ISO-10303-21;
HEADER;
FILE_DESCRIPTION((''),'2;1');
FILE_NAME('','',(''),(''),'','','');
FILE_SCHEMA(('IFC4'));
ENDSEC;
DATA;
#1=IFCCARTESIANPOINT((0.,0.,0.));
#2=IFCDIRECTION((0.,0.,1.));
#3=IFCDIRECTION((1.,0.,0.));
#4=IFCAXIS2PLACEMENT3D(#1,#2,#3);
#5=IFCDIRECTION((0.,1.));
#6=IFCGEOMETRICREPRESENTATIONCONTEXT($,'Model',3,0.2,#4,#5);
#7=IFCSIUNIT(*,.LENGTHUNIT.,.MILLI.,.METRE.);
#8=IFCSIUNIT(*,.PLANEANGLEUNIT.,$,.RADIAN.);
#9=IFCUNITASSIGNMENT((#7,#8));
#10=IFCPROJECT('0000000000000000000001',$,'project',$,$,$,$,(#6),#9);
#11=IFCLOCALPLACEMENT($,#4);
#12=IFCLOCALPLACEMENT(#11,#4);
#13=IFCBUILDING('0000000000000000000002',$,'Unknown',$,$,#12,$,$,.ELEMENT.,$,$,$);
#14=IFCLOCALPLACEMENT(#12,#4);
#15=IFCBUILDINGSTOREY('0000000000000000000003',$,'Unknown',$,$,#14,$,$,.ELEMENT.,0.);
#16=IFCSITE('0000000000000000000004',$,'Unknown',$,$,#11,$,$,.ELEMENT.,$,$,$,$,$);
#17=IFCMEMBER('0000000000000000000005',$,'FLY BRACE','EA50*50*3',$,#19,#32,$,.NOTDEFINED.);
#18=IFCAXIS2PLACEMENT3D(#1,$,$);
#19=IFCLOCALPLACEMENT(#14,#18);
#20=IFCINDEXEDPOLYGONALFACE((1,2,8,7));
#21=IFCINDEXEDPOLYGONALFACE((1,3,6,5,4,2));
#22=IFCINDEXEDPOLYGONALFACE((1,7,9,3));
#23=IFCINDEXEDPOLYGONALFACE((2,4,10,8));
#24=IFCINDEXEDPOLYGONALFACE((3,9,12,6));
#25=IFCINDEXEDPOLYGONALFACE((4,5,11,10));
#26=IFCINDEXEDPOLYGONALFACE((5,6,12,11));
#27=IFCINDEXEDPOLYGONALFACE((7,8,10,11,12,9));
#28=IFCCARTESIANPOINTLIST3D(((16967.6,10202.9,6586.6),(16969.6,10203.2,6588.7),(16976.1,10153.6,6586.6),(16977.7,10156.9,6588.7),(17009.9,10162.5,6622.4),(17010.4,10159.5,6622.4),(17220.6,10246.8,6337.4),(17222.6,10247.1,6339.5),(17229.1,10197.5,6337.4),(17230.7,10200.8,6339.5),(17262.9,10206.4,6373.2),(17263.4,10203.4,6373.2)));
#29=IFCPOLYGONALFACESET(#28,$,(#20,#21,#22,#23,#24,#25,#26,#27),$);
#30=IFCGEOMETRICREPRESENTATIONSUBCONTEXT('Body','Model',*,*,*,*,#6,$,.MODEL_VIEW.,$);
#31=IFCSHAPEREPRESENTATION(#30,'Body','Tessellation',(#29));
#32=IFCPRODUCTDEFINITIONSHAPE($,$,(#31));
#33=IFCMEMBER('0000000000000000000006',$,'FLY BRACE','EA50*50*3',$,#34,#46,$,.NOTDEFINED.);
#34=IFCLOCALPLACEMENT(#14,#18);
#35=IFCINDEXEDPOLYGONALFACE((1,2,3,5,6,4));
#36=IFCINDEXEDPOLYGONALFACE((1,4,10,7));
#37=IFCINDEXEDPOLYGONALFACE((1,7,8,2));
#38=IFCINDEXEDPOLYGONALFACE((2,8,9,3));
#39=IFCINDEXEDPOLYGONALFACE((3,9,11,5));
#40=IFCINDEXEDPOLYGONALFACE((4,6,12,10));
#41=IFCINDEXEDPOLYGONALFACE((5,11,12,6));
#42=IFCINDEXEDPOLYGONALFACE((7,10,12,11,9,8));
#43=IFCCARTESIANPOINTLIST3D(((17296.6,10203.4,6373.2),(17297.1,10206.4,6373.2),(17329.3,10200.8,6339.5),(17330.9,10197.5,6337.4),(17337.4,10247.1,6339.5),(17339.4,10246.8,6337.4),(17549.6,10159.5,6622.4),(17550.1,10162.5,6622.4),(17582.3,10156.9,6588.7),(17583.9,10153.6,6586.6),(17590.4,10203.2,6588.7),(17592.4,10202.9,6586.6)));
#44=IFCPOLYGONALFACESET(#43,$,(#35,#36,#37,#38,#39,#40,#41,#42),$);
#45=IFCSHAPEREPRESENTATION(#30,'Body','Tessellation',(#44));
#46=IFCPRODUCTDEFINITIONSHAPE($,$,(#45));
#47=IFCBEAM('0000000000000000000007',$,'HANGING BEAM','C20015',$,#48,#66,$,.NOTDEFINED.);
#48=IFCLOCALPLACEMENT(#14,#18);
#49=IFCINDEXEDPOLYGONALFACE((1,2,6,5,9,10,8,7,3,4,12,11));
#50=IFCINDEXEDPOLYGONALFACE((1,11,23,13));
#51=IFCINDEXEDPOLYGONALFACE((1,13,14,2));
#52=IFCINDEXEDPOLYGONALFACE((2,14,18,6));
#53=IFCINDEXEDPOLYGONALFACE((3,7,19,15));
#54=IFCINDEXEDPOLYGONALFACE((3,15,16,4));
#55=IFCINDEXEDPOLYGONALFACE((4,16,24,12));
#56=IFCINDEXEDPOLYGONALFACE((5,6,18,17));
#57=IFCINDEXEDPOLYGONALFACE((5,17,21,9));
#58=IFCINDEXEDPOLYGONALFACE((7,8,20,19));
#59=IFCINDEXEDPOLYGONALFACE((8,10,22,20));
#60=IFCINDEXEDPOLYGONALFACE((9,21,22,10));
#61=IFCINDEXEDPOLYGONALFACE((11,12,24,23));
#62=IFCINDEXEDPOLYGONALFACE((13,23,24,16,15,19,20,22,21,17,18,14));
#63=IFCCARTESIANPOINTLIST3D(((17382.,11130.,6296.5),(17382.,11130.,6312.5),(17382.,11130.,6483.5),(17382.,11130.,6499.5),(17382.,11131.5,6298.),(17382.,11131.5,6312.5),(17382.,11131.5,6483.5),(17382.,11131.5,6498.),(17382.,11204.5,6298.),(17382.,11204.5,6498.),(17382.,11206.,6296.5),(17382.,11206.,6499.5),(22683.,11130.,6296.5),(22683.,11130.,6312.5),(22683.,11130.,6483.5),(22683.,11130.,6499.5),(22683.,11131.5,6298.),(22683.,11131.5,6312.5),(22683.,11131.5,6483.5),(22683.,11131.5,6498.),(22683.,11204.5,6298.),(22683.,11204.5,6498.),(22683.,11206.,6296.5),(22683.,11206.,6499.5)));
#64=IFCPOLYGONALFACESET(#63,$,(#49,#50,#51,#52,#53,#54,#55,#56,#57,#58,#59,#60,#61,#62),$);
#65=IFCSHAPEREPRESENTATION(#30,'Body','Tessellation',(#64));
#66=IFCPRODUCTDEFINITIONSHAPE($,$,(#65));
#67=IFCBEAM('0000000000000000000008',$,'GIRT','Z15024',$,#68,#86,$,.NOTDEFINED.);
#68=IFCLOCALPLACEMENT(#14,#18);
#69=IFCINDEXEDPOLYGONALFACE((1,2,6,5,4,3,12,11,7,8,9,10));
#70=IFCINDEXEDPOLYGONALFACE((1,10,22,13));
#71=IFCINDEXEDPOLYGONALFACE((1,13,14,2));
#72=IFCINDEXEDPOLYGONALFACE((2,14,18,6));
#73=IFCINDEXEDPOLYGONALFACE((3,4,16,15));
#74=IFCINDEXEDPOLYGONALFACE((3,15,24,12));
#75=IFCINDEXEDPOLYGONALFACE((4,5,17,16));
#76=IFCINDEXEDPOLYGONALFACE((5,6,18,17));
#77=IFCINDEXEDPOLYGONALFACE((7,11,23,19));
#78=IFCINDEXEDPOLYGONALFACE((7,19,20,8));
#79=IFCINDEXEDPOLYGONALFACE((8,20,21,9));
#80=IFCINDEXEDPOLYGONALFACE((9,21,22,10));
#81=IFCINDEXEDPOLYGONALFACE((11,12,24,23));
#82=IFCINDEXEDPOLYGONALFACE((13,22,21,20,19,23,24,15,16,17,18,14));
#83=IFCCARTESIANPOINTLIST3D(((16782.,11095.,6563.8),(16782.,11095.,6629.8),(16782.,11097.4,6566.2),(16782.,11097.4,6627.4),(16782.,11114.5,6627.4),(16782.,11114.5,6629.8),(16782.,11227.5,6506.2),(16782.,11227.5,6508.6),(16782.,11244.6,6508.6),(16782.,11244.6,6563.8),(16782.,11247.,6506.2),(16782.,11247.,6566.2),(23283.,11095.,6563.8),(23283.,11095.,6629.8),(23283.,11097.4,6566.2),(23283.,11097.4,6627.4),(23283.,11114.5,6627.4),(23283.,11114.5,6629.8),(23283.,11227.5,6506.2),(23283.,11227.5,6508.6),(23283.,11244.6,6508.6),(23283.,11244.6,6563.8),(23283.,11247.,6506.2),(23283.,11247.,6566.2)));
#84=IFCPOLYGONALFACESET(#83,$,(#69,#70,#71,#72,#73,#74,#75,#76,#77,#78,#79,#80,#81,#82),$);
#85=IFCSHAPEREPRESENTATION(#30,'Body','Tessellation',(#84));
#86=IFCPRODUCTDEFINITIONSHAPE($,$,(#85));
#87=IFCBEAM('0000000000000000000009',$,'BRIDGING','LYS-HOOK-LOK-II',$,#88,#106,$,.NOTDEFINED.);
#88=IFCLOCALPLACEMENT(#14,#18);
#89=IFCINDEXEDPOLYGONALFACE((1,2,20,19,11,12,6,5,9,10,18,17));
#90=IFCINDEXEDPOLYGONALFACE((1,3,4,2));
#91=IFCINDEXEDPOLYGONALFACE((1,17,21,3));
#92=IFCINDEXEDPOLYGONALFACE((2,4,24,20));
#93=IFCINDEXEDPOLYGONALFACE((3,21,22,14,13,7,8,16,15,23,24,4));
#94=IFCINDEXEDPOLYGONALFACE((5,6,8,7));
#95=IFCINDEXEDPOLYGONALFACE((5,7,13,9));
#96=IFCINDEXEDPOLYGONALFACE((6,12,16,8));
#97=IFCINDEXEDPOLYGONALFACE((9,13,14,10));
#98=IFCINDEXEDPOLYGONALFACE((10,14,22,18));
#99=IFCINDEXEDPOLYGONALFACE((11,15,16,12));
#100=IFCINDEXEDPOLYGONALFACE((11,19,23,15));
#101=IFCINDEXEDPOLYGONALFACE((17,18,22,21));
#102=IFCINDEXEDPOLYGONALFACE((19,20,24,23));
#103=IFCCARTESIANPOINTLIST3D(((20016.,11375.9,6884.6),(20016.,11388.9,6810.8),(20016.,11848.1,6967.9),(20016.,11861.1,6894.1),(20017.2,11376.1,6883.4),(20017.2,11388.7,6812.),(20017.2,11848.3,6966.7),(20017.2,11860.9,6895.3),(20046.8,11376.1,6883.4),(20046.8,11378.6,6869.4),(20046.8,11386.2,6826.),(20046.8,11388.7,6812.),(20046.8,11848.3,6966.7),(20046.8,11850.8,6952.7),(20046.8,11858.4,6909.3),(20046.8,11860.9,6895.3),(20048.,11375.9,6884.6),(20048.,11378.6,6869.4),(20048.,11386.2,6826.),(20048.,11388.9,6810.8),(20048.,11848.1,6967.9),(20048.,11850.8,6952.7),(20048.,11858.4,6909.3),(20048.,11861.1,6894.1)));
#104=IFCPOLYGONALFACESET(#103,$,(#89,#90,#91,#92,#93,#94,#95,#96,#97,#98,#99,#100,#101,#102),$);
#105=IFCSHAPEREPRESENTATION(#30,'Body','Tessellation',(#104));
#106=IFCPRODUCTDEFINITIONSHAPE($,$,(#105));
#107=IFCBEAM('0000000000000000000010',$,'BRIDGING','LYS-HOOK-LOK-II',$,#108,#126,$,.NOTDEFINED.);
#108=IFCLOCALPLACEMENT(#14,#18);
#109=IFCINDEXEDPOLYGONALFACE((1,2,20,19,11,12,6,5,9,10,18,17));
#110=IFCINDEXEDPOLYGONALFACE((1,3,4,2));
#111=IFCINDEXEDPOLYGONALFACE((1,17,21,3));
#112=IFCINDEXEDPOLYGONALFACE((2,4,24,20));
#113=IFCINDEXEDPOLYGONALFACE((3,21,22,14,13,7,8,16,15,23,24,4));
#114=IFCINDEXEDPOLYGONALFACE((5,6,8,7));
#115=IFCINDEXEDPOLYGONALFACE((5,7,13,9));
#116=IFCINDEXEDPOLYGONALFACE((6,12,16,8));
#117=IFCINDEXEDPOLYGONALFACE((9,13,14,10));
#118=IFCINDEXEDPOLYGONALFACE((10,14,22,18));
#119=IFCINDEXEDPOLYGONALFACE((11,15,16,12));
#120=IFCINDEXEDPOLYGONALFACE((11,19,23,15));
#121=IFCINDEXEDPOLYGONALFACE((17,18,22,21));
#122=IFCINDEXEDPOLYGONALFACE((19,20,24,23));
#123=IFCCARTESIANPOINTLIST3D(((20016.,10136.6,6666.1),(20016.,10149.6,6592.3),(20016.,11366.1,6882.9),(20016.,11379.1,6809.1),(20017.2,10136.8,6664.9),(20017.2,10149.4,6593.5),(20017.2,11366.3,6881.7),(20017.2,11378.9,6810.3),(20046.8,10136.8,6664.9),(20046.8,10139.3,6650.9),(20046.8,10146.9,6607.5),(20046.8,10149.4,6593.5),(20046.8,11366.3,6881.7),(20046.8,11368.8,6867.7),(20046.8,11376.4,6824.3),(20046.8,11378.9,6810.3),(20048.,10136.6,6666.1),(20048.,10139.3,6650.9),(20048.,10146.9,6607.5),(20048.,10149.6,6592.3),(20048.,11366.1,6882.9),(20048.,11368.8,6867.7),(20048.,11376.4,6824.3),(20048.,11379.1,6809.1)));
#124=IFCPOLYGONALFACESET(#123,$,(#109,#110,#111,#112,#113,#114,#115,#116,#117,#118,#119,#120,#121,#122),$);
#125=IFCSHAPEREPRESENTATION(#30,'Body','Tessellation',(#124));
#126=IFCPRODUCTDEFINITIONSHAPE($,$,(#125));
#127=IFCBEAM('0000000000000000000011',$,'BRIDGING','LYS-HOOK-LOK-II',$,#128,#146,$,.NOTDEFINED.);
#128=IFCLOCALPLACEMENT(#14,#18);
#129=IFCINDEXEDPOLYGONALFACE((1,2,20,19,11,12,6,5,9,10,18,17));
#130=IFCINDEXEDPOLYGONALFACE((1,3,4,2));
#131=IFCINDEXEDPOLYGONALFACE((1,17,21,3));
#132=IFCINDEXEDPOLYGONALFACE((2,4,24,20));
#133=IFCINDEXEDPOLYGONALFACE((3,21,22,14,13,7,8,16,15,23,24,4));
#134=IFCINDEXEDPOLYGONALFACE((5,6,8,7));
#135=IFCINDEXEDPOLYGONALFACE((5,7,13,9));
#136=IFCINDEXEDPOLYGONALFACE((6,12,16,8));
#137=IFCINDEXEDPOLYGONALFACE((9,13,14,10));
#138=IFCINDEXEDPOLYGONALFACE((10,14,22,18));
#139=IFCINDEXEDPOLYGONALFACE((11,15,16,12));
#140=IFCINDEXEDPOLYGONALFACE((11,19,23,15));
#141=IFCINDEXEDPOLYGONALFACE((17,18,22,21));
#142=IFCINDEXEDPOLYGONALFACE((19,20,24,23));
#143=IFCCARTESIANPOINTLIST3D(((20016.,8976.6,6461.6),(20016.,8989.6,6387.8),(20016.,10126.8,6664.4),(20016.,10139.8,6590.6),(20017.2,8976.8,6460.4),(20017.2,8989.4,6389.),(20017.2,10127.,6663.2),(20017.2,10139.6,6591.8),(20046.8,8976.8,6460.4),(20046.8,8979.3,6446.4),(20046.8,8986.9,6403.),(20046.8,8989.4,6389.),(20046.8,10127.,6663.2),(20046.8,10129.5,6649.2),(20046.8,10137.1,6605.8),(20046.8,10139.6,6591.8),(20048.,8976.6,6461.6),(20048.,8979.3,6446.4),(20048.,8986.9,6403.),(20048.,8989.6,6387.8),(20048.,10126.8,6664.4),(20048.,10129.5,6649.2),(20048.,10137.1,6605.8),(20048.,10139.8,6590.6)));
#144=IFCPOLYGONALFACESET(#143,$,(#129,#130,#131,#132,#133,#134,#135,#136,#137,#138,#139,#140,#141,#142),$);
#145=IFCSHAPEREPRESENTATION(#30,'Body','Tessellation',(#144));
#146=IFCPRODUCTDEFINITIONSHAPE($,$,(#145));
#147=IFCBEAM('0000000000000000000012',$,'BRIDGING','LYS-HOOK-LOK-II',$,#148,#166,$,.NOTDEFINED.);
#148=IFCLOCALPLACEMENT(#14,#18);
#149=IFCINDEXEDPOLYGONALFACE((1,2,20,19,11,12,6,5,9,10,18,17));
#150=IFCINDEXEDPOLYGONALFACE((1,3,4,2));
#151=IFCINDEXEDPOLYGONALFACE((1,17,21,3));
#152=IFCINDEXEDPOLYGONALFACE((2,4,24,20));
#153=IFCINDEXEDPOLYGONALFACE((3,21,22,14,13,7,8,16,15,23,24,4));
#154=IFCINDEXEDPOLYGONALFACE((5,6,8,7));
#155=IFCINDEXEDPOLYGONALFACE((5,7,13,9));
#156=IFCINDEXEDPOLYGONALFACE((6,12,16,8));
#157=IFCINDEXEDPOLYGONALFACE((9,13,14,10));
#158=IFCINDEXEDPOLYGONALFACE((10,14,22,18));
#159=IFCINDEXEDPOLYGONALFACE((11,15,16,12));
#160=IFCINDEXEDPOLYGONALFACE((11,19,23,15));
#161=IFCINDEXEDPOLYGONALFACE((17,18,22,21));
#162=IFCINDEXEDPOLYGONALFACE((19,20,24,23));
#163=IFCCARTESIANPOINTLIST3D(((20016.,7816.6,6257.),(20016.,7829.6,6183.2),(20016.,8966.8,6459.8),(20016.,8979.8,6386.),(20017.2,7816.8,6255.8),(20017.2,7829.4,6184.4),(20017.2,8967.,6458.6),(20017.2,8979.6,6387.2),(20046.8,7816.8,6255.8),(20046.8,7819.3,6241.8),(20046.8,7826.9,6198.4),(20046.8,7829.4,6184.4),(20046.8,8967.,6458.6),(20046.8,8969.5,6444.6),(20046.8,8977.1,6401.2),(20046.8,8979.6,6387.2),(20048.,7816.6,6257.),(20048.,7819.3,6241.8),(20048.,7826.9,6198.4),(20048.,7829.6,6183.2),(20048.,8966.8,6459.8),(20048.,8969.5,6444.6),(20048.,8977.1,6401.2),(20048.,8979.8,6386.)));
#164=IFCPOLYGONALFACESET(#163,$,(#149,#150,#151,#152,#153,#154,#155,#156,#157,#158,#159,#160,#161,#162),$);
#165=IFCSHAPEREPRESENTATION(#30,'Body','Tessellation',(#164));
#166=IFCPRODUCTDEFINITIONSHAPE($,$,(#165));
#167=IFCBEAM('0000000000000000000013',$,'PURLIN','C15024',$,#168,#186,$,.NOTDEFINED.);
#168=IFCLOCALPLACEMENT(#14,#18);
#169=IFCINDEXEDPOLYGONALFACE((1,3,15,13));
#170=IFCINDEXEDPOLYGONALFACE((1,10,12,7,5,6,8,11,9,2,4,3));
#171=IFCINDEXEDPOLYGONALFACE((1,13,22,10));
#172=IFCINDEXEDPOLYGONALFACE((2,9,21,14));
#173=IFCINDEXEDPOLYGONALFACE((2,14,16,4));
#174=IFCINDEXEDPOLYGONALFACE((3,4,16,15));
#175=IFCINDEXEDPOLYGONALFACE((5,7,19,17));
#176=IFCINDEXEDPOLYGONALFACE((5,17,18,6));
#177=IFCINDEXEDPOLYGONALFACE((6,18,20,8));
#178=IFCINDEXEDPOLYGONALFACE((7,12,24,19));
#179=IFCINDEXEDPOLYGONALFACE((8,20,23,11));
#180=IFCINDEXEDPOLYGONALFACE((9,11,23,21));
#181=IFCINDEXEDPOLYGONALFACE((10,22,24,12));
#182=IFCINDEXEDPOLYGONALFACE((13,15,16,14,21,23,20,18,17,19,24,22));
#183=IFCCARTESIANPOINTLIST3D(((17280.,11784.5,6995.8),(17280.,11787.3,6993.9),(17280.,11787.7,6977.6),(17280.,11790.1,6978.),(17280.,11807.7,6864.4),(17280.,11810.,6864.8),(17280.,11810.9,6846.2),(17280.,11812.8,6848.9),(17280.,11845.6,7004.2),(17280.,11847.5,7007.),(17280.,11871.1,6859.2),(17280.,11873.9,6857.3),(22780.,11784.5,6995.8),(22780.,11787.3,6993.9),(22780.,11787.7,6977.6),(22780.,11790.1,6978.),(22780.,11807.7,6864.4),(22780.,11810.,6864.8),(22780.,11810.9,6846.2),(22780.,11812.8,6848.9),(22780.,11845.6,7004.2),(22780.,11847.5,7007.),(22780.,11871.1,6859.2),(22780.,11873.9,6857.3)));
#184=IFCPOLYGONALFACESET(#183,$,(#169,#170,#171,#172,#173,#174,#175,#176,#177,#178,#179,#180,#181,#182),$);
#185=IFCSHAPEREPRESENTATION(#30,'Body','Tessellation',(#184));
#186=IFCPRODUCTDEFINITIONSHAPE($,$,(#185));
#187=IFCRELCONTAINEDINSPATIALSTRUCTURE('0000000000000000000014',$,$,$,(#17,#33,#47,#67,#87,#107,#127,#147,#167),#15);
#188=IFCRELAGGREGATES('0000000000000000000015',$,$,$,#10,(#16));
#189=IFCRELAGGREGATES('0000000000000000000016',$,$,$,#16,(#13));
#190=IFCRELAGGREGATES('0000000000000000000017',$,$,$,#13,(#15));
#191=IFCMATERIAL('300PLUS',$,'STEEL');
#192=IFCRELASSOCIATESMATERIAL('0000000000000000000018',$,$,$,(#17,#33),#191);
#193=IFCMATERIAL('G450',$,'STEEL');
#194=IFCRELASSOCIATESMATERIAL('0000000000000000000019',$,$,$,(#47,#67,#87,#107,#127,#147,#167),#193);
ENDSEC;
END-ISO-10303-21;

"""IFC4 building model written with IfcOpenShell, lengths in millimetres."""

from ifc_helpers import new_model, si_unit, direction, frame, origin_with_axes, place, context, subcontext, project, spatial, line, indexed_curve, outline, extrude, material, element, save


model = new_model("IFC4")

# Units and contexts
model_context = context("Model", 3, precision=0.2, world=origin_with_axes(), true_north=direction((0.0, 1.0)))
body_context = subcontext(model_context, "Body", "Model", "MODEL_VIEW")
ifc_project = project(units=[si_unit("LENGTHUNIT", "METRE", prefix="MILLI"), si_unit("PLANEANGLEUNIT", "RADIAN")], contexts=[model_context])

# Site, building, storey
site_placement = place(None, origin_with_axes())
site = spatial("IfcSite", under=ifc_project, at=site_placement, Name="Unknown", CompositionType="ELEMENT")
building_placement = place(site_placement, origin_with_axes())
building = spatial("IfcBuilding", under=site, at=building_placement, Name="Unknown", CompositionType="ELEMENT")
storey_placement = place(building_placement, origin_with_axes())
storey = spatial("IfcBuildingStorey", under=building, at=storey_placement, Name="Unknown", CompositionType="ELEMENT", Elevation=0.0)

# Members
ifc_material_1 = material(Name="300PLUS", Category="STEEL")
for number, where, z_axis, x_axis, name in (
    (1, (16989.0, 10181.2, 6604.5), (0.686182, 0.119065, 0.71762), (0.707055, 0.122687, -0.696435), "FLY BRACE"),
    (2, (17571.0, 10181.2, 6604.5), (0.170963, 0.985277, 0.0), (-0.707055, 0.122687, -0.696435), "FLY BRACE"),
):
    element("IfcMember", number, at=place(storey_placement, frame(where, z_axis=z_axis, x_axis=x_axis)), inside=storey, material=ifc_material_1, Name=name, Description="EA50*50*3", PredefinedType="NOTDEFINED", context=body_context, shape_type="SolidModel", body=[
        extrude(outline(indexed_curve([(-25.0, -25.0), (25.0, -25.0), (25.0, -22.0), (-22.0, -22.0), (-22.0, 25.0), (-25.0, 25.0)], segments=[line(1, 2, 3, 4, 5, 6, 1)])), frame((0.0, 0.0, 0.0), z_axis=(-1.0, 0.0, 0.0), x_axis=(0.0, 0.0, 1.0)), (0.0, 0.0, -1.0), 357.8),
    ])

# Beams
ifc_material_2 = material(Name="G450", Category="STEEL")
beam_1_placement = place(storey_placement, frame((17382.0, 11168.0, 6398.0), z_axis=(0.0, -1.0, 0.0), x_axis=(1.0, 0.0, 0.0)))
element("IfcBeam", 3, at=beam_1_placement, inside=storey, material=ifc_material_2, Name="HANGING BEAM", Description="C20015", PredefinedType="NOTDEFINED", context=body_context, shape_type="SolidModel", body=[
    extrude(outline(indexed_curve([(38.0, -101.5), (38.0, -85.5), (36.5, -85.5), (36.5, -100.0), (-36.5, -100.0), (-36.5, 100.0), (36.5, 100.0), (36.5, 85.5), (38.0, 85.5), (38.0, 101.5), (-38.0, 101.5), (-38.0, -101.5)], segments=[line(1, 2, 3, 4, 5, 6, 7, 8, 9, 10, 11, 12, 1)])), frame((0.0, 0.0, 0.0), z_axis=(-1.0, 0.0, 0.0), x_axis=(0.0, 0.0, 1.0)), (0.0, 0.0, -1.0), 5301.0),
])
beam_2_placement = place(storey_placement, frame((16782.0, 11171.0, 6565.0), z_axis=(0.0, 0.0, -1.0), x_axis=(1.0, 0.0, 0.0)))
element("IfcBeam", 4, at=beam_2_placement, inside=storey, material=ifc_material_2, Name="GIRT", Description="Z15024", PredefinedType="NOTDEFINED", context=body_context, shape_type="SolidModel", body=[
    extrude(outline(indexed_curve([(58.8, -76.0), (58.8, -56.5), (56.4, -56.5), (56.4, -73.6), (1.2, -73.6), (1.2, 76.0), (-64.8, 76.0), (-64.8, 56.5), (-62.4, 56.5), (-62.4, 73.6), (-1.2, 73.6), (-1.2, -76.0)], segments=[line(1, 2, 3, 4, 5, 6, 7, 8, 9, 10, 11, 12, 1)])), frame((0.0, 0.0, 0.0), z_axis=(-1.0, 0.0, 0.0), x_axis=(0.0, 0.0, 1.0)), (0.0, 0.0, -1.0), 6501.0),
])
beam_3_placement = place(storey_placement, frame((20032.0, 11382.4, 6847.7), z_axis=(1.0, 0.0, 0.0), x_axis=(0.0, 0.984794, 0.173726)))
element("IfcBeam", 5, at=beam_3_placement, inside=storey, material=ifc_material_2, Name="BRIDGING", Description="LYS-HOOK-LOK-II", PredefinedType="NOTDEFINED", context=body_context, shape_type="SolidModel", body=[
    extrude(outline(indexed_curve([(16.0, -37.5), (16.0, -22.0), (14.8, -22.0), (14.8, -36.3), (-14.8, -36.3), (-14.8, 36.3), (14.8, 36.3), (14.8, 22.0), (16.0, 22.0), (16.0, 37.5), (-16.0, 37.5), (-16.0, -37.5)], segments=[line(1, 2, 3, 4, 5, 6, 7, 8, 9, 10, 11, 12, 1)])), frame((0.0, 0.0, 0.0), z_axis=(-1.0, 0.0, 0.0), x_axis=(0.0, 0.0, 1.0)), (0.0, 0.0, -1.0), 479.5),
])
beam_4_placement = place(storey_placement, frame((20032.0, 10143.1, 6629.2), z_axis=(1.0, 0.0, 0.0), x_axis=(0.0, 0.984807, 0.173653)))
element("IfcBeam", 6, at=beam_4_placement, inside=storey, material=ifc_material_2, Name="BRIDGING", Description="LYS-HOOK-LOK-II", PredefinedType="NOTDEFINED", context=body_context, shape_type="SolidModel", body=[
    extrude(outline(indexed_curve([(16.0, -37.5), (16.0, -22.0), (14.8, -22.0), (14.8, -36.3), (-14.8, -36.3), (-14.8, 36.3), (14.8, 36.3), (14.8, 22.0), (16.0, 22.0), (16.0, 37.5), (-16.0, 37.5), (-16.0, -37.5)], segments=[line(1, 2, 3, 4, 5, 6, 7, 8, 9, 10, 11, 12, 1)])), frame((0.0, 0.0, 0.0), z_axis=(-1.0, 0.0, 0.0), x_axis=(0.0, 0.0, 1.0)), (0.0, 0.0, -1.0), 1248.5),
])
for number, where, z_axis, x_axis, name in (
    (7, (20032.0, 8983.1, 6424.7), (1.0, 0.0, 0.0), (0.0, 0.984809, 0.173639), "BRIDGING"),
    (8, (20032.0, 7823.1, 6220.1), (1.0, 0.0, 0.0), (0.0, 0.984809, 0.173639), "BRIDGING"),
):
    element("IfcBeam", number, at=place(storey_placement, frame(where, z_axis=z_axis, x_axis=x_axis)), inside=storey, material=ifc_material_2, Name=name, Description="LYS-HOOK-LOK-II", PredefinedType="NOTDEFINED", context=body_context, shape_type="SolidModel", body=[
        extrude(outline(indexed_curve([(16.0, -37.5), (16.0, -22.0), (14.8, -22.0), (14.8, -36.3), (-14.8, -36.3), (-14.8, 36.3), (14.8, 36.3), (14.8, 22.0), (16.0, 22.0), (16.0, 37.5), (-16.0, 37.5), (-16.0, -37.5)], segments=[line(1, 2, 3, 4, 5, 6, 7, 8, 9, 10, 11, 12, 1)])), frame((0.0, 0.0, 0.0), z_axis=(-1.0, 0.0, 0.0), x_axis=(0.0, 0.0, 1.0)), (0.0, 0.0, -1.0), 1167.9),
    ])
beam_5_placement = place(storey_placement, frame((17280.0, 11829.2, 6926.6), z_axis=(0.0, -0.984808, -0.173648), x_axis=(1.0, 0.0, 0.0)))
element("IfcBeam", 9, at=beam_5_placement, inside=storey, material=ifc_material_2, Name="PURLIN", Description="C15024", PredefinedType="NOTDEFINED", context=body_context, shape_type="SolidModel", body=[
    extrude(outline(indexed_curve([(32.0, -76.0), (32.0, -57.5), (29.6, -57.5), (29.6, -73.6), (-29.6, -73.6), (-29.6, 73.6), (29.6, 73.6), (29.6, 57.5), (32.0, 57.5), (32.0, 76.0), (-32.0, 76.0), (-32.0, -76.0)], segments=[line(1, 2, 3, 4, 5, 6, 7, 8, 9, 10, 11, 12, 1)])), frame((0.0, 0.0, 0.0), z_axis=(-1.0, 0.0, 0.0), x_axis=(0.0, 0.0, 1.0)), (0.0, 0.0, -1.0), 5500.0),
])

save(model, "model.ifc")
